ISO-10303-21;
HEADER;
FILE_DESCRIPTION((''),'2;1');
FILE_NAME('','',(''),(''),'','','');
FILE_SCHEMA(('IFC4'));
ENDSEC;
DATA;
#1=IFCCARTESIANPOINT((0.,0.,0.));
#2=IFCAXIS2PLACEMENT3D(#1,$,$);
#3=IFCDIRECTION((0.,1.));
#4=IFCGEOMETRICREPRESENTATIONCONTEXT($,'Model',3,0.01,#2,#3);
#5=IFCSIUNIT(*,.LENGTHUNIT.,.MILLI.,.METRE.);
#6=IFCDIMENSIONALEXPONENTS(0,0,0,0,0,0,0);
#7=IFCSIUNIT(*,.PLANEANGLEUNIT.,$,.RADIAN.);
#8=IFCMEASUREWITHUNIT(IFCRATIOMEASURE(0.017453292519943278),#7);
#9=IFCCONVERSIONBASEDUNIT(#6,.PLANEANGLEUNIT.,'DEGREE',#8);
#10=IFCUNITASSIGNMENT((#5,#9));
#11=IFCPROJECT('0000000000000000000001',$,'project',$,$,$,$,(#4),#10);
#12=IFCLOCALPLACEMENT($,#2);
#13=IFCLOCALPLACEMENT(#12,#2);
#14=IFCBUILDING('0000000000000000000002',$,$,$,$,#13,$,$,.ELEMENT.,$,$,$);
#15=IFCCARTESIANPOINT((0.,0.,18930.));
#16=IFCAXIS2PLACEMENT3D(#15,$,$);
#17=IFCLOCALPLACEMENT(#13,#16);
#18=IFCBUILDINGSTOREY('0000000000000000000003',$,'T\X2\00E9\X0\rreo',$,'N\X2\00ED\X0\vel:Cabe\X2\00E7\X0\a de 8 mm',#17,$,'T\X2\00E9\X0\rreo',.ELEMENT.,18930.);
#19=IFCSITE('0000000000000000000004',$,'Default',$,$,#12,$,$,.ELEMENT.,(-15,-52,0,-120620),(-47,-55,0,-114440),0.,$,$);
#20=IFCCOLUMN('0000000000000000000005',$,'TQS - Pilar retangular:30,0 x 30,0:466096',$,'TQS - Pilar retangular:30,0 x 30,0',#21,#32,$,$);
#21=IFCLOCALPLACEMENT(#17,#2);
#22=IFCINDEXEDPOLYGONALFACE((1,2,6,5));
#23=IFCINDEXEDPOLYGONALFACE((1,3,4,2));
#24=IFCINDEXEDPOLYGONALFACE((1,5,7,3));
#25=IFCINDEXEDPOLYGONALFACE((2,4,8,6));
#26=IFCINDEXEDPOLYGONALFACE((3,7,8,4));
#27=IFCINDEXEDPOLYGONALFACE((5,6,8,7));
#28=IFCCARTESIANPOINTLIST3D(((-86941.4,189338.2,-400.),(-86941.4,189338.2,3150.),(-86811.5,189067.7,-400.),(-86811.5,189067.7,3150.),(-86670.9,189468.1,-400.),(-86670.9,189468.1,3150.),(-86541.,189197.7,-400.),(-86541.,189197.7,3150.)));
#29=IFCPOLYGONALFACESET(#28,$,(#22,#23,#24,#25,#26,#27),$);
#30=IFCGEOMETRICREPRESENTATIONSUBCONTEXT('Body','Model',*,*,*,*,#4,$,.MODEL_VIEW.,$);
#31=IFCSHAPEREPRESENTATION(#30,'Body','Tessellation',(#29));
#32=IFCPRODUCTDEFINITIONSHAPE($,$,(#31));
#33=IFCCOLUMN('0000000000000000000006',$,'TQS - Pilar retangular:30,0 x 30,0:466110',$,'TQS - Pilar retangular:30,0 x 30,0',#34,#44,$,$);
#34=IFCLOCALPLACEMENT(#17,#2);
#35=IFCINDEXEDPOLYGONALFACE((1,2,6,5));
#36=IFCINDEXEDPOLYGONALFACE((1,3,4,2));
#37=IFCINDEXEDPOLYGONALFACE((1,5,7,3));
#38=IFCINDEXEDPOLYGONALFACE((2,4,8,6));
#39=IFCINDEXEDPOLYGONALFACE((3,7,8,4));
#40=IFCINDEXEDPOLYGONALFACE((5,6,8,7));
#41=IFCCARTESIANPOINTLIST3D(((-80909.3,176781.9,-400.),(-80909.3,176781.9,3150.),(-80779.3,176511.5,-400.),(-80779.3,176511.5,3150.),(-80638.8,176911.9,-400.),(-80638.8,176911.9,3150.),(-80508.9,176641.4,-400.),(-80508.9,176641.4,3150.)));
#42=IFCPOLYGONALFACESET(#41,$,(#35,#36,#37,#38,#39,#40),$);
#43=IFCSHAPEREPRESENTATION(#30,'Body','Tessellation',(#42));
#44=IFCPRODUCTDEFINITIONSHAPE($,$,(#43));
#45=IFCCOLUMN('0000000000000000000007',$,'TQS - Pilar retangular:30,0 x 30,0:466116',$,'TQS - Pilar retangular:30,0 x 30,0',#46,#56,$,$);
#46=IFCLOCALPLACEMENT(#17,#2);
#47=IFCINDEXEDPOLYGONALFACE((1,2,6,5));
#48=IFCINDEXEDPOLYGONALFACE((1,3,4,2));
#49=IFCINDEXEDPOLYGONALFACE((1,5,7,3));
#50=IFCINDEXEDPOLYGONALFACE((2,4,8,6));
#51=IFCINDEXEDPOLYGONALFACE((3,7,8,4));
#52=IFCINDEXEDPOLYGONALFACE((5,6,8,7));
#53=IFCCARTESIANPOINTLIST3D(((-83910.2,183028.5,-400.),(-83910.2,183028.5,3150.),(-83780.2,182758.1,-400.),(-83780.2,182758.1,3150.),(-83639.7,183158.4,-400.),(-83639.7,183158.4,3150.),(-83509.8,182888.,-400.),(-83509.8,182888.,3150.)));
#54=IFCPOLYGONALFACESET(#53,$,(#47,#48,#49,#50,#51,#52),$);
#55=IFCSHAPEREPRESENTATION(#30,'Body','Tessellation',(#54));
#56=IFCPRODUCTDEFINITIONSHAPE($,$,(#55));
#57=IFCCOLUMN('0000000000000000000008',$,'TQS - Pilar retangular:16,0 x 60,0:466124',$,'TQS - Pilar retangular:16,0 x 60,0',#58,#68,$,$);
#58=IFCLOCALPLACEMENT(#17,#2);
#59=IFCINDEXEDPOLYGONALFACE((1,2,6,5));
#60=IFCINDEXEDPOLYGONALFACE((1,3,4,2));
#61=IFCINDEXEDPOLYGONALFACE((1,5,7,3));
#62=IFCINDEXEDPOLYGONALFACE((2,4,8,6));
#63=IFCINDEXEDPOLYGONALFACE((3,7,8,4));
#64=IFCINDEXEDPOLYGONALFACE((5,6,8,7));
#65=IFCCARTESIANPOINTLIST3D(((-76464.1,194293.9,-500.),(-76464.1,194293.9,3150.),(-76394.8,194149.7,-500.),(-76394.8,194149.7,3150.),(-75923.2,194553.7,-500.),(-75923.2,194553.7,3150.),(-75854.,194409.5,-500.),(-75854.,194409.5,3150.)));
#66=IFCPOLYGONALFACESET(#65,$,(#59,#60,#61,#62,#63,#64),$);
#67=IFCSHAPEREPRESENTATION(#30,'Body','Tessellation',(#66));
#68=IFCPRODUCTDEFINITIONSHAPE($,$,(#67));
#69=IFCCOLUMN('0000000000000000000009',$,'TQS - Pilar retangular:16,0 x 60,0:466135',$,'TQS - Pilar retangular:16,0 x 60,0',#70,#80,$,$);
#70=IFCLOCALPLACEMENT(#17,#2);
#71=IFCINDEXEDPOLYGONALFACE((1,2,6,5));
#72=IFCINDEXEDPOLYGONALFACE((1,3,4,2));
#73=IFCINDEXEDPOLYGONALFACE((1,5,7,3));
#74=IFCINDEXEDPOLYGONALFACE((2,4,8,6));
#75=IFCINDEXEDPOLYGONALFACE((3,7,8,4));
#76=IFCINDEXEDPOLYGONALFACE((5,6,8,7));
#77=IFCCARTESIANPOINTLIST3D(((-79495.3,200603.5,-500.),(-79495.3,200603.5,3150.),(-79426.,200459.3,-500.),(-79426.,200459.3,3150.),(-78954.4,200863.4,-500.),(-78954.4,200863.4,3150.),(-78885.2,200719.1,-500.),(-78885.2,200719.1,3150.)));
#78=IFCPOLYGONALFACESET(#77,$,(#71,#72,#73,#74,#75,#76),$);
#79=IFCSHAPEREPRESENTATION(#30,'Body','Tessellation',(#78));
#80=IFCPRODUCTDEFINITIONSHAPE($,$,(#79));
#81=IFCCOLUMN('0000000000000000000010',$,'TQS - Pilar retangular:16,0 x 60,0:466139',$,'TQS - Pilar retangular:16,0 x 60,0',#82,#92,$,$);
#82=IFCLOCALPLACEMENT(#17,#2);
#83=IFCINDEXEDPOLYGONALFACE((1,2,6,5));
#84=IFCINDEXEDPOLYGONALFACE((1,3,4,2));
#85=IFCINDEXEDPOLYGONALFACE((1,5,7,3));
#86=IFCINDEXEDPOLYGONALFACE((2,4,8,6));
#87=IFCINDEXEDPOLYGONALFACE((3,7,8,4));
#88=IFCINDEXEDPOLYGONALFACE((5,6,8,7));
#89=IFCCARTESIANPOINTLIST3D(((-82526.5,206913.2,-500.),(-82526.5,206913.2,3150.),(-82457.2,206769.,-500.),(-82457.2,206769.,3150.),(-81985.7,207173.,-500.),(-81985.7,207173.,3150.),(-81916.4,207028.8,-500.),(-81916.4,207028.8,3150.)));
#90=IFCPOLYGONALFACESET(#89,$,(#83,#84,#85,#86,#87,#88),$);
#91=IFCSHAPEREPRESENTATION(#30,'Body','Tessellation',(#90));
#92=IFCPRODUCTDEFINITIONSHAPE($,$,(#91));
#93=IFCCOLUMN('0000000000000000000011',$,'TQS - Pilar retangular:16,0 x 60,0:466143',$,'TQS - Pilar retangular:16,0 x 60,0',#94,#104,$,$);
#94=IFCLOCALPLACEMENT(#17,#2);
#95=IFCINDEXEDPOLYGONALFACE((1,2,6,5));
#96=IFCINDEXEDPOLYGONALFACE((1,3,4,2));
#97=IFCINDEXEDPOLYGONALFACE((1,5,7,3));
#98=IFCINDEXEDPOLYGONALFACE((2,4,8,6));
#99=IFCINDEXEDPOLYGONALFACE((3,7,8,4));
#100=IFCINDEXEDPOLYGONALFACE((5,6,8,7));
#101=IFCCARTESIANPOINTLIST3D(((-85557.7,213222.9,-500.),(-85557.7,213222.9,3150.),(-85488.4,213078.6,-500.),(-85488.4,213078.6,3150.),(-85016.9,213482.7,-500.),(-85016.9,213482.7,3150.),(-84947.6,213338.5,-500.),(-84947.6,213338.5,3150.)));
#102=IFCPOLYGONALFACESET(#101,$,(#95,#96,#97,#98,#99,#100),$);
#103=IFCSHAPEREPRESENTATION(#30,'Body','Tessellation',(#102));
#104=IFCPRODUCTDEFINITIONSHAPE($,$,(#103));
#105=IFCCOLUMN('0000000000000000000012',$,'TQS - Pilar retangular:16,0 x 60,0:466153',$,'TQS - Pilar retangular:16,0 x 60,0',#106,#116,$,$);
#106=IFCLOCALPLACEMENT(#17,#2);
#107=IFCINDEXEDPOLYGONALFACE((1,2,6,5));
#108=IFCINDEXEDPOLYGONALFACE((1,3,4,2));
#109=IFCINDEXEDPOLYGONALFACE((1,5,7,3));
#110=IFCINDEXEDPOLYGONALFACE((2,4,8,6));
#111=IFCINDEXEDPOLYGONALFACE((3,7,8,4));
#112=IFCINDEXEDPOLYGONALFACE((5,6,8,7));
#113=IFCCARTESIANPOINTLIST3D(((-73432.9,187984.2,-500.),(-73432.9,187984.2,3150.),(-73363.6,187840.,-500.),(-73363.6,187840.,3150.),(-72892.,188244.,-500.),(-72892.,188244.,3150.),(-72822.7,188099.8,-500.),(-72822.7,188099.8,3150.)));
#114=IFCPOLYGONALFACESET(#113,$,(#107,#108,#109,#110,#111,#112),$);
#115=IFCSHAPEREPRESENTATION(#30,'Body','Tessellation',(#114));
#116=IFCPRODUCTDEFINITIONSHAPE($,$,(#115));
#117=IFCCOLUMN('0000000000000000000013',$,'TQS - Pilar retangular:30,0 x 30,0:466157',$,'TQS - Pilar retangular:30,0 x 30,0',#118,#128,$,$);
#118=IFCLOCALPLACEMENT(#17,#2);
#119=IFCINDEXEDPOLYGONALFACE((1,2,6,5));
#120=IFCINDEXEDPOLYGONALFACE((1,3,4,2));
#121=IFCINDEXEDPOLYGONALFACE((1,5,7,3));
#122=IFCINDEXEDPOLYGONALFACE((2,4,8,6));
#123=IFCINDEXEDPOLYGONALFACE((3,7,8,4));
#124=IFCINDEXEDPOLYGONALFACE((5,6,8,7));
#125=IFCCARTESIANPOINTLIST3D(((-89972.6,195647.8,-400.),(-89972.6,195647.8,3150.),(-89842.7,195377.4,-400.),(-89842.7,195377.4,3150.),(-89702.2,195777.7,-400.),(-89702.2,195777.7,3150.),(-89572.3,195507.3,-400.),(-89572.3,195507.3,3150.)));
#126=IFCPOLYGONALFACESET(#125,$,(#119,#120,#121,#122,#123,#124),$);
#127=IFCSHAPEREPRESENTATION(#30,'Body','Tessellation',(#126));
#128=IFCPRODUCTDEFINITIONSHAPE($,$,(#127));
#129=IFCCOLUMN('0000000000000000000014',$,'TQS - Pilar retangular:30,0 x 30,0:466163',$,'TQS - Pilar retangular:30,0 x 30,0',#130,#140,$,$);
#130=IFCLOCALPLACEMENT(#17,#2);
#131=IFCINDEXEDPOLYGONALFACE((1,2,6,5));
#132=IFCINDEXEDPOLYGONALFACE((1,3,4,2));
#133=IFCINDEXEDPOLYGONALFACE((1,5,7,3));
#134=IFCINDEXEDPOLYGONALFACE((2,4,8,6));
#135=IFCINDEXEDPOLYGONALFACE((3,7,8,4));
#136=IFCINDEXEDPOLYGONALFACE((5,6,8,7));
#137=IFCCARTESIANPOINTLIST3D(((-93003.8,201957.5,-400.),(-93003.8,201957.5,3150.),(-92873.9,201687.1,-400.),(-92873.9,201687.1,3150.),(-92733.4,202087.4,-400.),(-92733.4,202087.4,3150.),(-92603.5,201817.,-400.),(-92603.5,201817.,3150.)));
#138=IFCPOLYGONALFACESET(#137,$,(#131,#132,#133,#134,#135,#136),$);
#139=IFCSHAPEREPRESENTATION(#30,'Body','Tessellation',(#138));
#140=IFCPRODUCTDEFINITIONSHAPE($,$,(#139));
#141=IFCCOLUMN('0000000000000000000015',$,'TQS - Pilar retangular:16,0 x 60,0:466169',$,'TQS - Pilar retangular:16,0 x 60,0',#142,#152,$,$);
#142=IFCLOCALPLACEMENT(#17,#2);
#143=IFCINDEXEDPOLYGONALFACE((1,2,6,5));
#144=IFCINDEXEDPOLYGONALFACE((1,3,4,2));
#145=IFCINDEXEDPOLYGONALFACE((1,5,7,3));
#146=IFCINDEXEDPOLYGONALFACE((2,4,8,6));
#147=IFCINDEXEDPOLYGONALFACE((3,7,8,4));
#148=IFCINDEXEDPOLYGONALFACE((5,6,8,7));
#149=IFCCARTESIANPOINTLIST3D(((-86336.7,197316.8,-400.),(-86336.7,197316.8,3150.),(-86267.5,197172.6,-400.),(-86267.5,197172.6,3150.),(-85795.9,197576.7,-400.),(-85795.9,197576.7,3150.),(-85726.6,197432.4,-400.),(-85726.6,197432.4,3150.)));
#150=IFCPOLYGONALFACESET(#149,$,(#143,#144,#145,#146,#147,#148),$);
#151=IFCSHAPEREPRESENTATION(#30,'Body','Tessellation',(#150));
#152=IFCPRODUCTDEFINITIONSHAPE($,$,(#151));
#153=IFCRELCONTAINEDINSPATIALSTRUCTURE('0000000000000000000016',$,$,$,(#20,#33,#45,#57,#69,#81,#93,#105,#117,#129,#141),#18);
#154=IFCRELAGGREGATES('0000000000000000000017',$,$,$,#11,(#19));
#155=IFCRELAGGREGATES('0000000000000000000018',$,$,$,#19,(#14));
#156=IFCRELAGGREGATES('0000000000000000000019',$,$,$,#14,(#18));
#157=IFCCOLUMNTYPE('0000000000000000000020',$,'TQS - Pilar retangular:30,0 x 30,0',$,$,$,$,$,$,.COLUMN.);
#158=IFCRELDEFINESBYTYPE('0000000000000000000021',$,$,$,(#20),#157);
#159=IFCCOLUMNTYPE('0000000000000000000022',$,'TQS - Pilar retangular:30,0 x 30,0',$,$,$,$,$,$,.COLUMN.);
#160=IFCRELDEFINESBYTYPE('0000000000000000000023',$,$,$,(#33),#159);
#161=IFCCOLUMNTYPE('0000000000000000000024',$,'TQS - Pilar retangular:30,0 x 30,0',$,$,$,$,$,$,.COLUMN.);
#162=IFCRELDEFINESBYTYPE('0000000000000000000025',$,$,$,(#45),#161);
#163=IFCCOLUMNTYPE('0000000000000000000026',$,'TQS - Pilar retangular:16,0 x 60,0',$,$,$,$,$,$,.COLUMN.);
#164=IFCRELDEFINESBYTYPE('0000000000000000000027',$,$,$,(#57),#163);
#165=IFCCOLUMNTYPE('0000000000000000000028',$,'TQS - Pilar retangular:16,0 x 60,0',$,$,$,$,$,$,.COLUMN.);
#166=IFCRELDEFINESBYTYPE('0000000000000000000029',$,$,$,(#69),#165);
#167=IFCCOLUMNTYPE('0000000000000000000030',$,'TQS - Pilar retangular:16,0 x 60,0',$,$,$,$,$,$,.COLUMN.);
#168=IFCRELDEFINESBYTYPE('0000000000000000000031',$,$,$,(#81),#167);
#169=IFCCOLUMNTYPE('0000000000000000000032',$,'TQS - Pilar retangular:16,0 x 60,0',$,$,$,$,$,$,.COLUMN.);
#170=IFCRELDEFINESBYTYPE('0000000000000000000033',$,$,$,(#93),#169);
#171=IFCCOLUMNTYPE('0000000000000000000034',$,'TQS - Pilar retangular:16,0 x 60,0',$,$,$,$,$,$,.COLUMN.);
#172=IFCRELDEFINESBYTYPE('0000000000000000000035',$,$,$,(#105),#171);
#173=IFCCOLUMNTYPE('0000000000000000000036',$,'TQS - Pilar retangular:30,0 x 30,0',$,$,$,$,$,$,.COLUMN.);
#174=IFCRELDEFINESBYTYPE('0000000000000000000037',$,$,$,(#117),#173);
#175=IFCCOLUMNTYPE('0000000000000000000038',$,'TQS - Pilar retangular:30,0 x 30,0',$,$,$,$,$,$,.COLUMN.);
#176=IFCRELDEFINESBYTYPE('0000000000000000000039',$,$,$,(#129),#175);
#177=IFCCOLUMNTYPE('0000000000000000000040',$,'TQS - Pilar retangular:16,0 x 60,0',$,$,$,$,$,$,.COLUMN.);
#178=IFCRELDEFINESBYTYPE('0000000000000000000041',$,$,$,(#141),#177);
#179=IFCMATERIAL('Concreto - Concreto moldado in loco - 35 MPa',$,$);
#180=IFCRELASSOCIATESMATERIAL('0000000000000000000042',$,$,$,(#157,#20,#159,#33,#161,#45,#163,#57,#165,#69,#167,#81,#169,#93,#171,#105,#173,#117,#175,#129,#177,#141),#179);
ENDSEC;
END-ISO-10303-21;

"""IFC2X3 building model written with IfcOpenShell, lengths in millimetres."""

from ifc_helpers import new_model, entity, si_unit, converted_unit, direction, frame, origin, origin_2d_with_axis, place, context, subcontext, project, spatial, rectangle, extrude, source, transform, mapped, material, type_object, type_shapes, element, save


model = new_model("IFC2X3")

# Units and contexts
model_context = context("Model", 3, precision=0.01, world=origin(), true_north=direction((0.0, 1.0)))
body_context = subcontext(model_context, "Body", "Model", "MODEL_VIEW")
ifc_project = project(units=[si_unit("LENGTHUNIT", "METRE", prefix="MILLI"), converted_unit("PLANEANGLEUNIT", "DEGREE", entity("IfcRatioMeasure", 0.017453292519943278), si_unit("PLANEANGLEUNIT", "RADIAN"), dimensions=[0, 0, 0, 0, 0, 0, 0])], contexts=[model_context])

# Site, building, storey
site_placement = place(None, origin())
site = spatial("IfcSite", under=ifc_project, at=site_placement, Name="Default", CompositionType="ELEMENT", RefLatitude=(-15, -52, 0, -120620), RefLongitude=(-47, -55, 0, -114440), RefElevation=0.0)
building_placement = place(site_placement, origin())
building = spatial("IfcBuilding", under=site, at=building_placement, CompositionType="ELEMENT")
storey_placement = place(building_placement, frame((0.0, 0.0, 18930.0)))
storey = spatial("IfcBuildingStorey", under=building, at=storey_placement, Name="Térreo", ObjectType="Nível:Cabeça de 8 mm", LongName="Térreo", CompositionType="ELEMENT", Elevation=18930.0)

# Columns
ifc_material = material(Name="Concreto - Concreto moldado in loco - 35 MPa")
column_type_1 = type_object("IfcColumnType", Name="TQS - Pilar retangular:30,0 x 30,0", PredefinedType="COLUMN", material=ifc_material)
shared_shape_1 = source(origin(), body_context, "Body", "SweptSolid", [
    extrude(rectangle(XDim=300.0, YDim=300.0, at=origin_2d_with_axis()), frame((-86741.2, 189267.9, 18530.0), z_axis=(0.0, 0.0, 1.0), x_axis=(-0.90138, -0.43303, 0.0)), (0.0, 0.0, 1.0), 3550.0),
])
type_shapes(column_type_1, [shared_shape_1])
column_1_placement = place(storey_placement, frame((0.0, 0.0, -18930.0)))
element("IfcColumn", 1, at=column_1_placement, inside=storey, type_object=column_type_1, material=ifc_material, Name="TQS - Pilar retangular:30,0 x 30,0:466096", ObjectType="TQS - Pilar retangular:30,0 x 30,0", context=body_context, shape_type="MappedRepresentation", body=[
    mapped(shared_shape_1, transform((0.0, 0.0, 0.0), scale=1.0)),
])
column_type_2 = type_object("IfcColumnType", Name="TQS - Pilar retangular:30,0 x 30,0", PredefinedType="COLUMN", material=ifc_material)
shared_shape_2 = source(origin(), body_context, "Body", "SweptSolid", [
    extrude(rectangle(XDim=300.0, YDim=300.0, at=origin_2d_with_axis()), frame((-80709.1, 176711.7, 18530.0), z_axis=(0.0, 0.0, 1.0), x_axis=(-0.90138, -0.43303, 0.0)), (0.0, 0.0, 1.0), 3550.0),
])
type_shapes(column_type_2, [shared_shape_2])
column_2_placement = place(storey_placement, frame((0.0, 0.0, -18930.0)))
element("IfcColumn", 2, at=column_2_placement, inside=storey, type_object=column_type_2, material=ifc_material, Name="TQS - Pilar retangular:30,0 x 30,0:466110", ObjectType="TQS - Pilar retangular:30,0 x 30,0", context=body_context, shape_type="MappedRepresentation", body=[
    mapped(shared_shape_2, transform((0.0, 0.0, 0.0), scale=1.0)),
])
column_type_3 = type_object("IfcColumnType", Name="TQS - Pilar retangular:30,0 x 30,0", PredefinedType="COLUMN", material=ifc_material)
shared_shape_3 = source(origin(), body_context, "Body", "SweptSolid", [
    extrude(rectangle(XDim=300.0, YDim=300.0, at=origin_2d_with_axis()), frame((-83710.0, 182958.3, 18530.0), z_axis=(0.0, 0.0, 1.0), x_axis=(-0.90138, -0.43303, 0.0)), (0.0, 0.0, 1.0), 3550.0),
])
type_shapes(column_type_3, [shared_shape_3])
column_3_placement = place(storey_placement, frame((0.0, 0.0, -18930.0)))
element("IfcColumn", 3, at=column_3_placement, inside=storey, type_object=column_type_3, material=ifc_material, Name="TQS - Pilar retangular:30,0 x 30,0:466116", ObjectType="TQS - Pilar retangular:30,0 x 30,0", context=body_context, shape_type="MappedRepresentation", body=[
    mapped(shared_shape_3, transform((0.0, 0.0, 0.0), scale=1.0)),
])
column_type_4 = type_object("IfcColumnType", Name="TQS - Pilar retangular:16,0 x 60,0", PredefinedType="COLUMN", material=ifc_material)
shared_shape_4 = source(origin(), body_context, "Body", "SweptSolid", [
    extrude(rectangle(XDim=600.0, YDim=160.0, at=origin_2d_with_axis()), frame((-76159.0, 194351.7, 18430.0), z_axis=(0.0, 0.0, 1.0), x_axis=(-0.90138, -0.43303, 0.0)), (0.0, 0.0, 1.0), 3650.0),
])
type_shapes(column_type_4, [shared_shape_4])
column_4_placement = place(storey_placement, frame((0.0, 0.0, -18930.0)))
element("IfcColumn", 4, at=column_4_placement, inside=storey, type_object=column_type_4, material=ifc_material, Name="TQS - Pilar retangular:16,0 x 60,0:466124", ObjectType="TQS - Pilar retangular:16,0 x 60,0", context=body_context, shape_type="MappedRepresentation", body=[
    mapped(shared_shape_4, transform((0.0, 0.0, 0.0), scale=1.0)),
])
column_type_5 = type_object("IfcColumnType", Name="TQS - Pilar retangular:16,0 x 60,0", PredefinedType="COLUMN", material=ifc_material)
shared_shape_5 = source(origin(), body_context, "Body", "SweptSolid", [
    extrude(rectangle(XDim=600.0, YDim=160.0, at=origin_2d_with_axis()), frame((-79190.2, 200661.3, 18430.0), z_axis=(0.0, 0.0, 1.0), x_axis=(-0.90138, -0.43303, 0.0)), (0.0, 0.0, 1.0), 3650.0),
])
type_shapes(column_type_5, [shared_shape_5])
column_5_placement = place(storey_placement, frame((0.0, 0.0, -18930.0)))
element("IfcColumn", 5, at=column_5_placement, inside=storey, type_object=column_type_5, material=ifc_material, Name="TQS - Pilar retangular:16,0 x 60,0:466135", ObjectType="TQS - Pilar retangular:16,0 x 60,0", context=body_context, shape_type="MappedRepresentation", body=[
    mapped(shared_shape_5, transform((0.0, 0.0, 0.0), scale=1.0)),
])
column_type_6 = type_object("IfcColumnType", Name="TQS - Pilar retangular:16,0 x 60,0", PredefinedType="COLUMN", material=ifc_material)
shared_shape_6 = source(origin(), body_context, "Body", "SweptSolid", [
    extrude(rectangle(XDim=600.0, YDim=160.0, at=origin_2d_with_axis()), frame((-82221.4, 206971.0, 18430.0), z_axis=(0.0, 0.0, 1.0), x_axis=(-0.90138, -0.43303, 0.0)), (0.0, 0.0, 1.0), 3650.0),
])
type_shapes(column_type_6, [shared_shape_6])
column_6_placement = place(storey_placement, frame((0.0, 0.0, -18930.0)))
element("IfcColumn", 6, at=column_6_placement, inside=storey, type_object=column_type_6, material=ifc_material, Name="TQS - Pilar retangular:16,0 x 60,0:466139", ObjectType="TQS - Pilar retangular:16,0 x 60,0", context=body_context, shape_type="MappedRepresentation", body=[
    mapped(shared_shape_6, transform((0.0, 0.0, 0.0), scale=1.0)),
])
column_type_7 = type_object("IfcColumnType", Name="TQS - Pilar retangular:16,0 x 60,0", PredefinedType="COLUMN", material=ifc_material)
shared_shape_7 = source(origin(), body_context, "Body", "SweptSolid", [
    extrude(rectangle(XDim=600.0, YDim=160.0, at=origin_2d_with_axis()), frame((-85252.6, 213280.7, 18430.0), z_axis=(0.0, 0.0, 1.0), x_axis=(-0.90138, -0.43303, 0.0)), (0.0, 0.0, 1.0), 3650.0),
])
type_shapes(column_type_7, [shared_shape_7])
column_7_placement = place(storey_placement, frame((0.0, 0.0, -18930.0)))
element("IfcColumn", 7, at=column_7_placement, inside=storey, type_object=column_type_7, material=ifc_material, Name="TQS - Pilar retangular:16,0 x 60,0:466143", ObjectType="TQS - Pilar retangular:16,0 x 60,0", context=body_context, shape_type="MappedRepresentation", body=[
    mapped(shared_shape_7, transform((0.0, 0.0, 0.0), scale=1.0)),
])
column_type_8 = type_object("IfcColumnType", Name="TQS - Pilar retangular:16,0 x 60,0", PredefinedType="COLUMN", material=ifc_material)
shared_shape_8 = source(origin(), body_context, "Body", "SweptSolid", [
    extrude(rectangle(XDim=600.0, YDim=160.0, at=origin_2d_with_axis()), frame((-73127.8, 188042.0, 18430.0), z_axis=(0.0, 0.0, 1.0), x_axis=(-0.90138, -0.43303, 0.0)), (0.0, 0.0, 1.0), 3650.0),
])
type_shapes(column_type_8, [shared_shape_8])
column_8_placement = place(storey_placement, frame((0.0, 0.0, -18930.0)))
element("IfcColumn", 8, at=column_8_placement, inside=storey, type_object=column_type_8, material=ifc_material, Name="TQS - Pilar retangular:16,0 x 60,0:466153", ObjectType="TQS - Pilar retangular:16,0 x 60,0", context=body_context, shape_type="MappedRepresentation", body=[
    mapped(shared_shape_8, transform((0.0, 0.0, 0.0), scale=1.0)),
])
column_type_9 = type_object("IfcColumnType", Name="TQS - Pilar retangular:30,0 x 30,0", PredefinedType="COLUMN", material=ifc_material)
shared_shape_9 = source(origin(), body_context, "Body", "SweptSolid", [
    extrude(rectangle(XDim=300.0, YDim=300.0, at=origin_2d_with_axis()), frame((-89772.4, 195577.6, 18530.0), z_axis=(0.0, 0.0, 1.0), x_axis=(-0.90138, -0.43303, 0.0)), (0.0, 0.0, 1.0), 3550.0),
])
type_shapes(column_type_9, [shared_shape_9])
column_9_placement = place(storey_placement, frame((0.0, 0.0, -18930.0)))
element("IfcColumn", 9, at=column_9_placement, inside=storey, type_object=column_type_9, material=ifc_material, Name="TQS - Pilar retangular:30,0 x 30,0:466157", ObjectType="TQS - Pilar retangular:30,0 x 30,0", context=body_context, shape_type="MappedRepresentation", body=[
    mapped(shared_shape_9, transform((0.0, 0.0, 0.0), scale=1.0)),
])
column_type_10 = type_object("IfcColumnType", Name="TQS - Pilar retangular:30,0 x 30,0", PredefinedType="COLUMN", material=ifc_material)
shared_shape_10 = source(origin(), body_context, "Body", "SweptSolid", [
    extrude(rectangle(XDim=300.0, YDim=300.0, at=origin_2d_with_axis()), frame((-92803.6, 201887.2, 18530.0), z_axis=(0.0, 0.0, 1.0), x_axis=(-0.90138, -0.43303, 0.0)), (0.0, 0.0, 1.0), 3550.0),
])
type_shapes(column_type_10, [shared_shape_10])
column_10_placement = place(storey_placement, frame((0.0, 0.0, -18930.0)))
element("IfcColumn", 10, at=column_10_placement, inside=storey, type_object=column_type_10, material=ifc_material, Name="TQS - Pilar retangular:30,0 x 30,0:466163", ObjectType="TQS - Pilar retangular:30,0 x 30,0", context=body_context, shape_type="MappedRepresentation", body=[
    mapped(shared_shape_10, transform((0.0, 0.0, 0.0), scale=1.0)),
])
column_type_11 = type_object("IfcColumnType", Name="TQS - Pilar retangular:16,0 x 60,0", PredefinedType="COLUMN", material=ifc_material)
shared_shape_11 = source(origin(), body_context, "Body", "SweptSolid", [
    extrude(rectangle(XDim=600.0, YDim=160.0, at=origin_2d_with_axis()), frame((-86031.7, 197374.6, 18530.0), z_axis=(0.0, 0.0, 1.0), x_axis=(-0.90138, -0.43303, 0.0)), (0.0, 0.0, 1.0), 3550.0),
])
type_shapes(column_type_11, [shared_shape_11])
column_11_placement = place(storey_placement, frame((0.0, 0.0, -18930.0)))
element("IfcColumn", 11, at=column_11_placement, inside=storey, type_object=column_type_11, material=ifc_material, Name="TQS - Pilar retangular:16,0 x 60,0:466169", ObjectType="TQS - Pilar retangular:16,0 x 60,0", context=body_context, shape_type="MappedRepresentation", body=[
    mapped(shared_shape_11, transform((0.0, 0.0, 0.0), scale=1.0)),
])

save(model, "model.ifc")
